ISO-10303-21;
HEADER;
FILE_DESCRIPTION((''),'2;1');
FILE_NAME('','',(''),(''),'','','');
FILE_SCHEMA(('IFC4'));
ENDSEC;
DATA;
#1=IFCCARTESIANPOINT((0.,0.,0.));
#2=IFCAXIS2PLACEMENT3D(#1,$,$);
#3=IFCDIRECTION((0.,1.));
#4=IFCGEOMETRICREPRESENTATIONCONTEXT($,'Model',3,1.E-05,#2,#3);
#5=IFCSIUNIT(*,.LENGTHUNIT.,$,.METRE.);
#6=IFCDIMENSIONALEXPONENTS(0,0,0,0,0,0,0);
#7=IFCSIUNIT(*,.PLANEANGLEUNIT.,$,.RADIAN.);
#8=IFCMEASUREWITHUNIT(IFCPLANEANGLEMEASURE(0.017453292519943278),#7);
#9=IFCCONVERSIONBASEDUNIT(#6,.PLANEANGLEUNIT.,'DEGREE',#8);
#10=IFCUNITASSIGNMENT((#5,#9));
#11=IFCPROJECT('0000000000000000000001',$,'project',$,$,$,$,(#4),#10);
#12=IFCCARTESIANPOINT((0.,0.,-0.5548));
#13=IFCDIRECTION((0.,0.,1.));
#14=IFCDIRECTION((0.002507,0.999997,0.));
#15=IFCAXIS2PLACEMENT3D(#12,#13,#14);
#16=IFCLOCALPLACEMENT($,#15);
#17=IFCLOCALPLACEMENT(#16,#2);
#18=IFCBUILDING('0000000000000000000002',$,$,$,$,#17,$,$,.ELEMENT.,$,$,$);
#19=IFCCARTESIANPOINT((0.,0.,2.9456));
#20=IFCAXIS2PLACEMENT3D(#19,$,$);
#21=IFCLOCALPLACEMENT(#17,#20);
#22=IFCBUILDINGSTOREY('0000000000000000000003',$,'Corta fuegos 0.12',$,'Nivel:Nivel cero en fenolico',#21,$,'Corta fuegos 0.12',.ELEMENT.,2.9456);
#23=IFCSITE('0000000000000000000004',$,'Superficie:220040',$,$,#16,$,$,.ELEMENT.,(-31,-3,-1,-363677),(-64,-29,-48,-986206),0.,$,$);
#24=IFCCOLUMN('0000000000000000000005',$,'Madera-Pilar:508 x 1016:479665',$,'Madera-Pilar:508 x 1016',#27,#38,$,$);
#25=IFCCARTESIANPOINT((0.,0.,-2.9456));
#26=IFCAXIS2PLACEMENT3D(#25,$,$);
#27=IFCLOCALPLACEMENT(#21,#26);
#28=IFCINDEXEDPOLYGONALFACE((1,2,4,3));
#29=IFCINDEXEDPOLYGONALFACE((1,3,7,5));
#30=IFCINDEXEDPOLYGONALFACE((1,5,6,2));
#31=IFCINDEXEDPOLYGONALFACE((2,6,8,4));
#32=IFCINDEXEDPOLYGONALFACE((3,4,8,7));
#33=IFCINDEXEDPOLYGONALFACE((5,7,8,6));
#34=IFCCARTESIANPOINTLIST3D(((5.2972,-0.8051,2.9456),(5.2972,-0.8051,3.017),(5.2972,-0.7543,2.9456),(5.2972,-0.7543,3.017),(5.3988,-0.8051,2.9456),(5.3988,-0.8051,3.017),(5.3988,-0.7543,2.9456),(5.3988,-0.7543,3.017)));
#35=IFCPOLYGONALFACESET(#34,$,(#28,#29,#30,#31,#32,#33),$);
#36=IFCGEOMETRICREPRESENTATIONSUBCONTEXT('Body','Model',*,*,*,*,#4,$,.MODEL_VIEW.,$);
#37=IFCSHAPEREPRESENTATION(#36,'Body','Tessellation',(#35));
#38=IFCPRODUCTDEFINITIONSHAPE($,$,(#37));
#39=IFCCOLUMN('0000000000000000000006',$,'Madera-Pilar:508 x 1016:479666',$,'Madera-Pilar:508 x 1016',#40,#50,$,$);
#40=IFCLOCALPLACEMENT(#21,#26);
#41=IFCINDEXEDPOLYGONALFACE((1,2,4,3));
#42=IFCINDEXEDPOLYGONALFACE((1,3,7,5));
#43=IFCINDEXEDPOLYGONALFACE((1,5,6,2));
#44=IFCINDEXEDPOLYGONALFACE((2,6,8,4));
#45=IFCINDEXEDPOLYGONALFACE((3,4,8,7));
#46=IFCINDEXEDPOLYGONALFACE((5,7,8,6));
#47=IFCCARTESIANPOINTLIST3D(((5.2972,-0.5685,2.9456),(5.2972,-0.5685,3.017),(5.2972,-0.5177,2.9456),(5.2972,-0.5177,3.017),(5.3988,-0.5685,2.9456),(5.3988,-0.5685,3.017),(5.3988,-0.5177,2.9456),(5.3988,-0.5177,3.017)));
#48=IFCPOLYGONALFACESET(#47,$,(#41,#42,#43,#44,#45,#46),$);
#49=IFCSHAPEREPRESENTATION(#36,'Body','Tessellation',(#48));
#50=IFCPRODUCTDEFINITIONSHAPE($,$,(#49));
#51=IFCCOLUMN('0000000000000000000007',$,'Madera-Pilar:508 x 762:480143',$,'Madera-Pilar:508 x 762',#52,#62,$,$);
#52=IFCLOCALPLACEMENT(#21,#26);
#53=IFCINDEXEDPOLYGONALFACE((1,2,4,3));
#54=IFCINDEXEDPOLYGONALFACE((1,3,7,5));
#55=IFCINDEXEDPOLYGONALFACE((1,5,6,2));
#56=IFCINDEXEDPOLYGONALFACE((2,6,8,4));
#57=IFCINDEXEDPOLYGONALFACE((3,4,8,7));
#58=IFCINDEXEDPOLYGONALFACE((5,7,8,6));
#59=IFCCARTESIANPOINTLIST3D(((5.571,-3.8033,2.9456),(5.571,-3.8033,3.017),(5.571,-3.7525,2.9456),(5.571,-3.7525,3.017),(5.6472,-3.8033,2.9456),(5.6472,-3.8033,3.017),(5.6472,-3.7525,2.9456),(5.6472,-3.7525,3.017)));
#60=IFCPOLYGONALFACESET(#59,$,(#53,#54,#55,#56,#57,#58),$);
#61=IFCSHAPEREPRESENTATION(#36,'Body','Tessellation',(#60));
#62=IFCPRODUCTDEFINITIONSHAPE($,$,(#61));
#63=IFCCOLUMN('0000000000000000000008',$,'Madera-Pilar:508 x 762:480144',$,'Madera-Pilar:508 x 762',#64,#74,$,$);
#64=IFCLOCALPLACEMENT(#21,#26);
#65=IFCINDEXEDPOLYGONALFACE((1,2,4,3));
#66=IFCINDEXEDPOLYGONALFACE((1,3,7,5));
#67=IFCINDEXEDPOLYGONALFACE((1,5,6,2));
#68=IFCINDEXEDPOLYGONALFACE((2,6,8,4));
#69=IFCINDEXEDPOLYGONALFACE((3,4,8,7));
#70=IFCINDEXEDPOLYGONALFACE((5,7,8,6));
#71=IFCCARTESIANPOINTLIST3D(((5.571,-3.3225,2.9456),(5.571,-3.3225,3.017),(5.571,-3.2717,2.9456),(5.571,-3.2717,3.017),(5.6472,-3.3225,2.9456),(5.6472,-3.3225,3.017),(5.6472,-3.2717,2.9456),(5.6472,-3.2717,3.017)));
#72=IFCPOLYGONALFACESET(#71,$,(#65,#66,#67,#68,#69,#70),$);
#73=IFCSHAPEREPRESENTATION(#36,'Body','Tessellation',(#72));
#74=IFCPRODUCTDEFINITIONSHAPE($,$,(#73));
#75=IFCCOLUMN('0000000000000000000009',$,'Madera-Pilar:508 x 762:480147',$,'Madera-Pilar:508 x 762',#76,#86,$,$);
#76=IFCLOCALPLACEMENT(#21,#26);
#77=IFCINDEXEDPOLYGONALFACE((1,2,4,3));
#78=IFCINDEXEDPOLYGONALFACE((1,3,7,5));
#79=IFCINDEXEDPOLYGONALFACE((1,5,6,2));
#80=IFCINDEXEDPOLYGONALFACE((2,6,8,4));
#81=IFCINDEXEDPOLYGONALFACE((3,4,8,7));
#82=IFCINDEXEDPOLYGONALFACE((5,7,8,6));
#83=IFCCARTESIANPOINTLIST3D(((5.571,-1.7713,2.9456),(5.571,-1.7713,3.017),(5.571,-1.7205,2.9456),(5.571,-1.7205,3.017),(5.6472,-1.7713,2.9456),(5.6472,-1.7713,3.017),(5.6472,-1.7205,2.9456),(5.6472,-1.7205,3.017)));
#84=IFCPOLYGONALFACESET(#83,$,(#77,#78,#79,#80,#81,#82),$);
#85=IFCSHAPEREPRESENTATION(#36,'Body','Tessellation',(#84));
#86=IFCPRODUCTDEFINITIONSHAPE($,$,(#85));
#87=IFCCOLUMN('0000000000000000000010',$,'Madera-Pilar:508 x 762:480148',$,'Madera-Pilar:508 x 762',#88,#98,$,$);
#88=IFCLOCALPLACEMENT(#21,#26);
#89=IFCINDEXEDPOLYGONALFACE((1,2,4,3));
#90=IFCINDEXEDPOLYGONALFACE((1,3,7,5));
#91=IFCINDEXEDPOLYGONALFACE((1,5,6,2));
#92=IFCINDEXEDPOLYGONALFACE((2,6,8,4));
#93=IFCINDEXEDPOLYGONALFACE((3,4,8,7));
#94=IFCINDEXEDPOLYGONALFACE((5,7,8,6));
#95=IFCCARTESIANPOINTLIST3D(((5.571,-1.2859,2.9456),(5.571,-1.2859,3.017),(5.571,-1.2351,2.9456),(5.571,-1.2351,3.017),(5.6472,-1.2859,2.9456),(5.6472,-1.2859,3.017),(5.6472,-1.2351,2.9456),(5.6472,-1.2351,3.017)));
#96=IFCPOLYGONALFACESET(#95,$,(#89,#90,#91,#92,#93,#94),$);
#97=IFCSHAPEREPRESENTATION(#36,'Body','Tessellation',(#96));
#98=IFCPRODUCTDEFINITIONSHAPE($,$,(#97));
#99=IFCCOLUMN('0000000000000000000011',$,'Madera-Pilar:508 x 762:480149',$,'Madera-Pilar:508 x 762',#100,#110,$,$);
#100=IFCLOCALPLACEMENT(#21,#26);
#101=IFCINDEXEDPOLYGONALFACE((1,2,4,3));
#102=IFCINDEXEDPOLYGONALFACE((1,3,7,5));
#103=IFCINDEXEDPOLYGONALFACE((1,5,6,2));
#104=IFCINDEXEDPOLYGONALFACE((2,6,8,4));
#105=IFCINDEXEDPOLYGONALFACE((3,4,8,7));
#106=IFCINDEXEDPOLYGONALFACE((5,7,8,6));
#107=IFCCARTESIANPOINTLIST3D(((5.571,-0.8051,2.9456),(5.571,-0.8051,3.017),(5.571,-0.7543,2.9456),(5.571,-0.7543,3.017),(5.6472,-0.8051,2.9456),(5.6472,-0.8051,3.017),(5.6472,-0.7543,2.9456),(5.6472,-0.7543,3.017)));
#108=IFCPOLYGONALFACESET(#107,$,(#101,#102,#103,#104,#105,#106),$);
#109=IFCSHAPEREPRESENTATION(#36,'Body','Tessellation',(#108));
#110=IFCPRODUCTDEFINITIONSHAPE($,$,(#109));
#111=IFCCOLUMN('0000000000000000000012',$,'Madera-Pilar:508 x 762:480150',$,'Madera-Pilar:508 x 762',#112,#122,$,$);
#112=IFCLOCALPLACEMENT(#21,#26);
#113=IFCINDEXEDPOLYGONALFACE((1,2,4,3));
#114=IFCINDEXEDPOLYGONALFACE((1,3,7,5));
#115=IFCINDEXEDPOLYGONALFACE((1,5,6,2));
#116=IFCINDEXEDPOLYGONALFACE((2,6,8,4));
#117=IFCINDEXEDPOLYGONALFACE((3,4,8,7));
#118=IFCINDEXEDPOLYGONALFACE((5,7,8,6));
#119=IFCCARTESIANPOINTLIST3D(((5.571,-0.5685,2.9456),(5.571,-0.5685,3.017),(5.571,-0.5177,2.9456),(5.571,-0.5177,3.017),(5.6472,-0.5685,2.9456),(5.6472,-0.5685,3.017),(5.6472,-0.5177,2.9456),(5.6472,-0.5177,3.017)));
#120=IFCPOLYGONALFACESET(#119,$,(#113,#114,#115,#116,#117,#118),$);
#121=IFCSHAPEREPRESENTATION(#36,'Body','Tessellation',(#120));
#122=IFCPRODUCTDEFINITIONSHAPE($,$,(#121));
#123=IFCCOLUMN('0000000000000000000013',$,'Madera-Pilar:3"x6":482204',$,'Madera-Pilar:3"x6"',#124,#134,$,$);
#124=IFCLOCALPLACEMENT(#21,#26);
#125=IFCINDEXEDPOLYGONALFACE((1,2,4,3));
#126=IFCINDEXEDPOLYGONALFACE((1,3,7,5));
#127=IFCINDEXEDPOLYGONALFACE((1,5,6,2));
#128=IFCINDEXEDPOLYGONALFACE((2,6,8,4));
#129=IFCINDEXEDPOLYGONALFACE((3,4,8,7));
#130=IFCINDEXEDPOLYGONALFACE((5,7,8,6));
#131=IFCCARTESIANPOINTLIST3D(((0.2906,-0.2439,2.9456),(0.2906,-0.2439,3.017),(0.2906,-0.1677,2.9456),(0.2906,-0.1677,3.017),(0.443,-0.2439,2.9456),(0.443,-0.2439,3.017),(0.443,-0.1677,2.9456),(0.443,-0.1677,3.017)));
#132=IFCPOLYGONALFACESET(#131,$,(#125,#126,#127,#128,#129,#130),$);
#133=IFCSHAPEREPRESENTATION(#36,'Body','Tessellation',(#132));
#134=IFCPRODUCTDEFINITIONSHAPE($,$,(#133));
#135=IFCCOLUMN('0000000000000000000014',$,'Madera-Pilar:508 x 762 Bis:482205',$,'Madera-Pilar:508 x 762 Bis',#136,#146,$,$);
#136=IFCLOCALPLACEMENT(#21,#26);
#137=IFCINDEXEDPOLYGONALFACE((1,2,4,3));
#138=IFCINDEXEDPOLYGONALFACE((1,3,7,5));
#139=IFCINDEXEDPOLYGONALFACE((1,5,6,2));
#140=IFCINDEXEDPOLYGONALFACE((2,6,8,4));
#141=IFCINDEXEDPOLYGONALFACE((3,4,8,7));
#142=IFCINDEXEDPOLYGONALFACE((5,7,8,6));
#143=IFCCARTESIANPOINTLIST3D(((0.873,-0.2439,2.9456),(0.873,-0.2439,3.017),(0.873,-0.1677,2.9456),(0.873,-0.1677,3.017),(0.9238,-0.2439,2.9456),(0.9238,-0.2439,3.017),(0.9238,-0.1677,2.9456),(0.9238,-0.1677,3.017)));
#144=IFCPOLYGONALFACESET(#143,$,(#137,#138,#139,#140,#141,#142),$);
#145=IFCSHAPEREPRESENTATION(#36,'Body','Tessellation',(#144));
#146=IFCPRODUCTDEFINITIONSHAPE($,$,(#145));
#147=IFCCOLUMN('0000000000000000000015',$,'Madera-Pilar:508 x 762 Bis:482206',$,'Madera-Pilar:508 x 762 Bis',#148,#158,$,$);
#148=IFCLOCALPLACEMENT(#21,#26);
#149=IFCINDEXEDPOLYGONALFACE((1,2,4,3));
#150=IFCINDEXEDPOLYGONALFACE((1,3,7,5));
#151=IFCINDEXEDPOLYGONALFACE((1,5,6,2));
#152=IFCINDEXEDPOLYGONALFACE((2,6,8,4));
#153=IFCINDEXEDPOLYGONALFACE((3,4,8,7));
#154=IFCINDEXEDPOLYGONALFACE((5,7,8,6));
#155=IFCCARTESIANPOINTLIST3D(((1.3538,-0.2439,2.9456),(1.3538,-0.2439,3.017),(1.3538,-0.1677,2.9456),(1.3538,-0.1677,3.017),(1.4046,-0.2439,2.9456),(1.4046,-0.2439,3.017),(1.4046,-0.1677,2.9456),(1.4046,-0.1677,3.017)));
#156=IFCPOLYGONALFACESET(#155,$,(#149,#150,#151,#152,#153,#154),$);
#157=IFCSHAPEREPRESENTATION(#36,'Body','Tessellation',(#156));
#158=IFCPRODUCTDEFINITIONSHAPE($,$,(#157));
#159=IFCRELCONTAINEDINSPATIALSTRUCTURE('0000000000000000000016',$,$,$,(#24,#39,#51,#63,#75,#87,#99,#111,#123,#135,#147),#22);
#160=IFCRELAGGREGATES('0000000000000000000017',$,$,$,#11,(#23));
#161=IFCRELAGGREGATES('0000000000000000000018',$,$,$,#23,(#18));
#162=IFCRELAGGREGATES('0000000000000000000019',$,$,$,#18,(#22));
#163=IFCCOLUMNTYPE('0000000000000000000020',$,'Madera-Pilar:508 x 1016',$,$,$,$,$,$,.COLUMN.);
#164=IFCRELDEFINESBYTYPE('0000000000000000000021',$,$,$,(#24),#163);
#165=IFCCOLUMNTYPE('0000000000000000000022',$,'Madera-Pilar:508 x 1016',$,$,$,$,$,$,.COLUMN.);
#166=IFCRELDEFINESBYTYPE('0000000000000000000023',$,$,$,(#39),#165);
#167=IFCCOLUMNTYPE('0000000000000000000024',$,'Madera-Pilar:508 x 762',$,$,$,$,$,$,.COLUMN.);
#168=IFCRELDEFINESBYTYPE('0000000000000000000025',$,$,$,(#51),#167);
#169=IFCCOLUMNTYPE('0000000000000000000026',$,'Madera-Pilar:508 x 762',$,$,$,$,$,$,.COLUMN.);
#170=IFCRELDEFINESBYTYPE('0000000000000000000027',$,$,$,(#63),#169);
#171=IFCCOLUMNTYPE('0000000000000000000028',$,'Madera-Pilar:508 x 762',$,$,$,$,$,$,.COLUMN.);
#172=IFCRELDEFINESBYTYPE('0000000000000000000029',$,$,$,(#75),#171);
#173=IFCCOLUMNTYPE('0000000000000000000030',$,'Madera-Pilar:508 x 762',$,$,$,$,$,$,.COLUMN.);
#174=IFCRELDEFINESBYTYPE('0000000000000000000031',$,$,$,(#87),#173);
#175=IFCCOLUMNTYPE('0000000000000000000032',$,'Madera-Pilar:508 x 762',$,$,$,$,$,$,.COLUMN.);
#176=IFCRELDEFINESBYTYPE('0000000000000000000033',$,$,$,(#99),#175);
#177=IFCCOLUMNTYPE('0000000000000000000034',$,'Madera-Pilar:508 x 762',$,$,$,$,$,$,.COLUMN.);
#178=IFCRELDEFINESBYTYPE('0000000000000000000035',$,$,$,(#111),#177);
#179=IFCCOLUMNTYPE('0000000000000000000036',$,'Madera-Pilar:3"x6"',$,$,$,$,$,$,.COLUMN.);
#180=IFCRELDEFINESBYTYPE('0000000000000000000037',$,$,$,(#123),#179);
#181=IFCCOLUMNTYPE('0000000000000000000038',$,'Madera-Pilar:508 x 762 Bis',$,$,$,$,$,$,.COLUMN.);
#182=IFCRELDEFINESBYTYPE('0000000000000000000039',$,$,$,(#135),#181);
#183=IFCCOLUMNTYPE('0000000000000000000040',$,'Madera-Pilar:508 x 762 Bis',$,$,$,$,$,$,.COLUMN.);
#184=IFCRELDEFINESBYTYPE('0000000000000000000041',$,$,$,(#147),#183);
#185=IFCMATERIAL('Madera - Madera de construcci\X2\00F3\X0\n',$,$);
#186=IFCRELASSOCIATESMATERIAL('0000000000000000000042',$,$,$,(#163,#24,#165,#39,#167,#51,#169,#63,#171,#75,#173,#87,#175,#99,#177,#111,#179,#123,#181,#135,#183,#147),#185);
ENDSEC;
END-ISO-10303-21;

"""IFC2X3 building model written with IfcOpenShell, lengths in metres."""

from ifc_helpers import new_model, entity, si_unit, converted_unit, direction, frame, frame_2d, origin, origin_2d_with_axis, place, context, subcontext, project, spatial, rectangle, extrude, source, transform, mapped, material, type_object, type_shapes, element, save


model = new_model("IFC2X3")

# Units and contexts
model_context = context("Model", 3, precision=1e-05, world=origin(), true_north=direction((0.0, 1.0)))
body_context = subcontext(model_context, "Body", "Model", "MODEL_VIEW")
ifc_project = project(units=[si_unit("LENGTHUNIT", "METRE"), converted_unit("PLANEANGLEUNIT", "DEGREE", entity("IfcPlaneAngleMeasure", 0.017453292519943278), si_unit("PLANEANGLEUNIT", "RADIAN"), dimensions=[0, 0, 0, 0, 0, 0, 0])], contexts=[model_context])

# Site, building, storey
site_placement = place(None, frame((0.0, 0.0, -0.5548), z_axis=(0.0, 0.0, 1.0), x_axis=(0.002507, 0.999997, 0.0)))
site = spatial("IfcSite", under=ifc_project, at=site_placement, Name="Superficie:220040", CompositionType="ELEMENT", RefLatitude=(-31, -3, -1, -363677), RefLongitude=(-64, -29, -48, -986206), RefElevation=0.0)
building_placement = place(site_placement, origin())
building = spatial("IfcBuilding", under=site, at=building_placement, CompositionType="ELEMENT")
storey_placement = place(building_placement, frame((0.0, 0.0, 2.9456)))
storey = spatial("IfcBuildingStorey", under=building, at=storey_placement, Name="Corta fuegos 0.12", ObjectType="Nivel:Nivel cero en fenolico", LongName="Corta fuegos 0.12", CompositionType="ELEMENT", Elevation=2.9456)

# Columns
ifc_material_1 = material(Name="Madera - Madera de construcción")
column_type_1 = type_object("IfcColumnType", Name="Madera-Pilar:508 x 1016", PredefinedType="COLUMN", material=ifc_material_1)
shared_shape_1 = source(origin(), body_context, "Body", "SweptSolid", [
    extrude(rectangle(XDim=0.1016, YDim=0.0508, at=frame_2d((0.0, 0.0), x_axis=(1.0, 0.0))), frame((5.348, -0.7797, 2.9456), z_axis=(0.0, 0.0, 1.0), x_axis=(-1.0, 0.0, 0.0)), (0.0, 0.0, 1.0), 0.0714),
])
type_shapes(column_type_1, [shared_shape_1])
column_1_placement = place(storey_placement, frame((0.0, 0.0, -2.9456)))
element("IfcColumn", 1, at=column_1_placement, inside=storey, type_object=column_type_1, material=ifc_material_1, Name="Madera-Pilar:508 x 1016:479665", ObjectType="Madera-Pilar:508 x 1016", context=body_context, shape_type="MappedRepresentation", body=[
    mapped(shared_shape_1, transform((0.0, 0.0, 0.0), scale=1.0)),
])
column_type_2 = type_object("IfcColumnType", Name="Madera-Pilar:508 x 1016", PredefinedType="COLUMN", material=ifc_material_1)
shared_shape_2 = source(origin(), body_context, "Body", "SweptSolid", [
    extrude(rectangle(XDim=0.1016, YDim=0.0508, at=origin_2d_with_axis()), frame((5.348, -0.5431, 2.9456), z_axis=(0.0, 0.0, 1.0), x_axis=(-1.0, 0.0, 0.0)), (0.0, 0.0, 1.0), 0.0714),
])
type_shapes(column_type_2, [shared_shape_2])
column_2_placement = place(storey_placement, frame((0.0, 0.0, -2.9456)))
element("IfcColumn", 2, at=column_2_placement, inside=storey, type_object=column_type_2, material=ifc_material_1, Name="Madera-Pilar:508 x 1016:479666", ObjectType="Madera-Pilar:508 x 1016", context=body_context, shape_type="MappedRepresentation", body=[
    mapped(shared_shape_2, transform((0.0, 0.0, 0.0), scale=1.0)),
])
column_type_3 = type_object("IfcColumnType", Name="Madera-Pilar:508 x 762", PredefinedType="COLUMN", material=ifc_material_1)
shared_shape_3 = source(origin(), body_context, "Body", "SweptSolid", [
    extrude(rectangle(XDim=0.0762, YDim=0.0508, at=origin_2d_with_axis()), frame((5.6091, -3.7779, 2.9456), z_axis=(0.0, 0.0, 1.0), x_axis=(-1.0, 0.0, 0.0)), (0.0, 0.0, 1.0), 0.0714),
])
type_shapes(column_type_3, [shared_shape_3])
column_3_placement = place(storey_placement, frame((0.0, 0.0, -2.9456)))
element("IfcColumn", 3, at=column_3_placement, inside=storey, type_object=column_type_3, material=ifc_material_1, Name="Madera-Pilar:508 x 762:480143", ObjectType="Madera-Pilar:508 x 762", context=body_context, shape_type="MappedRepresentation", body=[
    mapped(shared_shape_3, transform((0.0, 0.0, 0.0), scale=1.0)),
])
column_type_4 = type_object("IfcColumnType", Name="Madera-Pilar:508 x 762", PredefinedType="COLUMN", material=ifc_material_1)
shared_shape_4 = source(origin(), body_context, "Body", "SweptSolid", [
    extrude(rectangle(XDim=0.0762, YDim=0.0508, at=origin_2d_with_axis()), frame((5.6091, -3.2971, 2.9456), z_axis=(0.0, 0.0, 1.0), x_axis=(-1.0, 0.0, 0.0)), (0.0, 0.0, 1.0), 0.0714),
])
type_shapes(column_type_4, [shared_shape_4])
column_4_placement = place(storey_placement, frame((0.0, 0.0, -2.9456)))
element("IfcColumn", 4, at=column_4_placement, inside=storey, type_object=column_type_4, material=ifc_material_1, Name="Madera-Pilar:508 x 762:480144", ObjectType="Madera-Pilar:508 x 762", context=body_context, shape_type="MappedRepresentation", body=[
    mapped(shared_shape_4, transform((0.0, 0.0, 0.0), scale=1.0)),
])
column_type_5 = type_object("IfcColumnType", Name="Madera-Pilar:508 x 762", PredefinedType="COLUMN", material=ifc_material_1)
shared_shape_5 = source(origin(), body_context, "Body", "SweptSolid", [
    extrude(rectangle(XDim=0.0762, YDim=0.0508, at=origin_2d_with_axis()), frame((5.6091, -1.7459, 2.9456), z_axis=(0.0, 0.0, 1.0), x_axis=(-1.0, 0.0, 0.0)), (0.0, 0.0, 1.0), 0.0714),
])
type_shapes(column_type_5, [shared_shape_5])
column_5_placement = place(storey_placement, frame((0.0, 0.0, -2.9456)))
element("IfcColumn", 5, at=column_5_placement, inside=storey, type_object=column_type_5, material=ifc_material_1, Name="Madera-Pilar:508 x 762:480147", ObjectType="Madera-Pilar:508 x 762", context=body_context, shape_type="MappedRepresentation", body=[
    mapped(shared_shape_5, transform((0.0, 0.0, 0.0), scale=1.0)),
])
column_type_6 = type_object("IfcColumnType", Name="Madera-Pilar:508 x 762", PredefinedType="COLUMN", material=ifc_material_1)
shared_shape_6 = source(origin(), body_context, "Body", "SweptSolid", [
    extrude(rectangle(XDim=0.0762, YDim=0.0508, at=origin_2d_with_axis()), frame((5.6091, -1.2605, 2.9456), z_axis=(0.0, 0.0, 1.0), x_axis=(-1.0, 0.0, 0.0)), (0.0, 0.0, 1.0), 0.0714),
])
type_shapes(column_type_6, [shared_shape_6])
column_6_placement = place(storey_placement, frame((0.0, 0.0, -2.9456)))
element("IfcColumn", 6, at=column_6_placement, inside=storey, type_object=column_type_6, material=ifc_material_1, Name="Madera-Pilar:508 x 762:480148", ObjectType="Madera-Pilar:508 x 762", context=body_context, shape_type="MappedRepresentation", body=[
    mapped(shared_shape_6, transform((0.0, 0.0, 0.0), scale=1.0)),
])
column_type_7 = type_object("IfcColumnType", Name="Madera-Pilar:508 x 762", PredefinedType="COLUMN", material=ifc_material_1)
shared_shape_7 = source(origin(), body_context, "Body", "SweptSolid", [
    extrude(rectangle(XDim=0.0762, YDim=0.0508, at=frame_2d((0.0, 0.0), x_axis=(1.0, 0.0))), frame((5.6091, -0.7797, 2.9456), z_axis=(0.0, 0.0, 1.0), x_axis=(-1.0, 0.0, 0.0)), (0.0, 0.0, 1.0), 0.0714),
])
type_shapes(column_type_7, [shared_shape_7])
column_7_placement = place(storey_placement, frame((0.0, 0.0, -2.9456)))
element("IfcColumn", 7, at=column_7_placement, inside=storey, type_object=column_type_7, material=ifc_material_1, Name="Madera-Pilar:508 x 762:480149", ObjectType="Madera-Pilar:508 x 762", context=body_context, shape_type="MappedRepresentation", body=[
    mapped(shared_shape_7, transform((0.0, 0.0, 0.0), scale=1.0)),
])
column_type_8 = type_object("IfcColumnType", Name="Madera-Pilar:508 x 762", PredefinedType="COLUMN", material=ifc_material_1)
shared_shape_8 = source(origin(), body_context, "Body", "SweptSolid", [
    extrude(rectangle(XDim=0.0762, YDim=0.0508, at=origin_2d_with_axis()), frame((5.6091, -0.5431, 2.9456), z_axis=(0.0, 0.0, 1.0), x_axis=(-1.0, 0.0, 0.0)), (0.0, 0.0, 1.0), 0.0714),
])
type_shapes(column_type_8, [shared_shape_8])
column_8_placement = place(storey_placement, frame((0.0, 0.0, -2.9456)))
element("IfcColumn", 8, at=column_8_placement, inside=storey, type_object=column_type_8, material=ifc_material_1, Name="Madera-Pilar:508 x 762:480150", ObjectType="Madera-Pilar:508 x 762", context=body_context, shape_type="MappedRepresentation", body=[
    mapped(shared_shape_8, transform((0.0, 0.0, 0.0), scale=1.0)),
])
column_type_9 = type_object("IfcColumnType", Name="Madera-Pilar:3\"x6\"", PredefinedType="COLUMN", material=ifc_material_1)
shared_shape_9 = source(origin(), body_context, "Body", "SweptSolid", [
    extrude(rectangle(XDim=0.1524, YDim=0.0762, at=frame_2d((0.0, 0.0), x_axis=(1.0, 0.0))), frame((0.3668, -0.2058, 2.9456), z_axis=(0.0, 0.0, 1.0), x_axis=(-1.0, 0.0, 0.0)), (0.0, 0.0, 1.0), 0.0714),
])
type_shapes(column_type_9, [shared_shape_9])
column_9_placement = place(storey_placement, frame((0.0, 0.0, -2.9456)))
element("IfcColumn", 9, at=column_9_placement, inside=storey, type_object=column_type_9, material=ifc_material_1, Name="Madera-Pilar:3\"x6\":482204", ObjectType="Madera-Pilar:3\"x6\"", context=body_context, shape_type="MappedRepresentation", body=[
    mapped(shared_shape_9, transform((0.0, 0.0, 0.0), scale=1.0)),
])
column_type_10 = type_object("IfcColumnType", Name="Madera-Pilar:508 x 762 Bis", PredefinedType="COLUMN", material=ifc_material_1)
shared_shape_10 = source(origin(), body_context, "Body", "SweptSolid", [
    extrude(rectangle(XDim=0.0508, YDim=0.0762, at=frame_2d((0.0, 0.0), x_axis=(1.0, 0.0))), frame((0.8984, -0.2058, 2.9456), z_axis=(0.0, 0.0, 1.0), x_axis=(-1.0, 0.0, 0.0)), (0.0, 0.0, 1.0), 0.0714),
])
type_shapes(column_type_10, [shared_shape_10])
column_10_placement = place(storey_placement, frame((0.0, 0.0, -2.9456)))
element("IfcColumn", 10, at=column_10_placement, inside=storey, type_object=column_type_10, material=ifc_material_1, Name="Madera-Pilar:508 x 762 Bis:482205", ObjectType="Madera-Pilar:508 x 762 Bis", context=body_context, shape_type="MappedRepresentation", body=[
    mapped(shared_shape_10, transform((0.0, 0.0, 0.0), scale=1.0)),
])
column_type_11 = type_object("IfcColumnType", Name="Madera-Pilar:508 x 762 Bis", PredefinedType="COLUMN", material=ifc_material_1)
shared_shape_11 = source(origin(), body_context, "Body", "SweptSolid", [
    extrude(rectangle(XDim=0.0508, YDim=0.0762, at=frame_2d((0.0, 0.0), x_axis=(1.0, 0.0))), frame((1.3792, -0.2058, 2.9456), z_axis=(0.0, 0.0, 1.0), x_axis=(-1.0, 0.0, 0.0)), (0.0, 0.0, 1.0), 0.0714),
])
type_shapes(column_type_11, [shared_shape_11])
column_11_placement = place(storey_placement, frame((0.0, 0.0, -2.9456)))
element("IfcColumn", 11, at=column_11_placement, inside=storey, type_object=column_type_11, material=ifc_material_1, Name="Madera-Pilar:508 x 762 Bis:482206", ObjectType="Madera-Pilar:508 x 762 Bis", context=body_context, shape_type="MappedRepresentation", body=[
    mapped(shared_shape_11, transform((0.0, 0.0, 0.0), scale=1.0)),
])

save(model, "model.ifc")
